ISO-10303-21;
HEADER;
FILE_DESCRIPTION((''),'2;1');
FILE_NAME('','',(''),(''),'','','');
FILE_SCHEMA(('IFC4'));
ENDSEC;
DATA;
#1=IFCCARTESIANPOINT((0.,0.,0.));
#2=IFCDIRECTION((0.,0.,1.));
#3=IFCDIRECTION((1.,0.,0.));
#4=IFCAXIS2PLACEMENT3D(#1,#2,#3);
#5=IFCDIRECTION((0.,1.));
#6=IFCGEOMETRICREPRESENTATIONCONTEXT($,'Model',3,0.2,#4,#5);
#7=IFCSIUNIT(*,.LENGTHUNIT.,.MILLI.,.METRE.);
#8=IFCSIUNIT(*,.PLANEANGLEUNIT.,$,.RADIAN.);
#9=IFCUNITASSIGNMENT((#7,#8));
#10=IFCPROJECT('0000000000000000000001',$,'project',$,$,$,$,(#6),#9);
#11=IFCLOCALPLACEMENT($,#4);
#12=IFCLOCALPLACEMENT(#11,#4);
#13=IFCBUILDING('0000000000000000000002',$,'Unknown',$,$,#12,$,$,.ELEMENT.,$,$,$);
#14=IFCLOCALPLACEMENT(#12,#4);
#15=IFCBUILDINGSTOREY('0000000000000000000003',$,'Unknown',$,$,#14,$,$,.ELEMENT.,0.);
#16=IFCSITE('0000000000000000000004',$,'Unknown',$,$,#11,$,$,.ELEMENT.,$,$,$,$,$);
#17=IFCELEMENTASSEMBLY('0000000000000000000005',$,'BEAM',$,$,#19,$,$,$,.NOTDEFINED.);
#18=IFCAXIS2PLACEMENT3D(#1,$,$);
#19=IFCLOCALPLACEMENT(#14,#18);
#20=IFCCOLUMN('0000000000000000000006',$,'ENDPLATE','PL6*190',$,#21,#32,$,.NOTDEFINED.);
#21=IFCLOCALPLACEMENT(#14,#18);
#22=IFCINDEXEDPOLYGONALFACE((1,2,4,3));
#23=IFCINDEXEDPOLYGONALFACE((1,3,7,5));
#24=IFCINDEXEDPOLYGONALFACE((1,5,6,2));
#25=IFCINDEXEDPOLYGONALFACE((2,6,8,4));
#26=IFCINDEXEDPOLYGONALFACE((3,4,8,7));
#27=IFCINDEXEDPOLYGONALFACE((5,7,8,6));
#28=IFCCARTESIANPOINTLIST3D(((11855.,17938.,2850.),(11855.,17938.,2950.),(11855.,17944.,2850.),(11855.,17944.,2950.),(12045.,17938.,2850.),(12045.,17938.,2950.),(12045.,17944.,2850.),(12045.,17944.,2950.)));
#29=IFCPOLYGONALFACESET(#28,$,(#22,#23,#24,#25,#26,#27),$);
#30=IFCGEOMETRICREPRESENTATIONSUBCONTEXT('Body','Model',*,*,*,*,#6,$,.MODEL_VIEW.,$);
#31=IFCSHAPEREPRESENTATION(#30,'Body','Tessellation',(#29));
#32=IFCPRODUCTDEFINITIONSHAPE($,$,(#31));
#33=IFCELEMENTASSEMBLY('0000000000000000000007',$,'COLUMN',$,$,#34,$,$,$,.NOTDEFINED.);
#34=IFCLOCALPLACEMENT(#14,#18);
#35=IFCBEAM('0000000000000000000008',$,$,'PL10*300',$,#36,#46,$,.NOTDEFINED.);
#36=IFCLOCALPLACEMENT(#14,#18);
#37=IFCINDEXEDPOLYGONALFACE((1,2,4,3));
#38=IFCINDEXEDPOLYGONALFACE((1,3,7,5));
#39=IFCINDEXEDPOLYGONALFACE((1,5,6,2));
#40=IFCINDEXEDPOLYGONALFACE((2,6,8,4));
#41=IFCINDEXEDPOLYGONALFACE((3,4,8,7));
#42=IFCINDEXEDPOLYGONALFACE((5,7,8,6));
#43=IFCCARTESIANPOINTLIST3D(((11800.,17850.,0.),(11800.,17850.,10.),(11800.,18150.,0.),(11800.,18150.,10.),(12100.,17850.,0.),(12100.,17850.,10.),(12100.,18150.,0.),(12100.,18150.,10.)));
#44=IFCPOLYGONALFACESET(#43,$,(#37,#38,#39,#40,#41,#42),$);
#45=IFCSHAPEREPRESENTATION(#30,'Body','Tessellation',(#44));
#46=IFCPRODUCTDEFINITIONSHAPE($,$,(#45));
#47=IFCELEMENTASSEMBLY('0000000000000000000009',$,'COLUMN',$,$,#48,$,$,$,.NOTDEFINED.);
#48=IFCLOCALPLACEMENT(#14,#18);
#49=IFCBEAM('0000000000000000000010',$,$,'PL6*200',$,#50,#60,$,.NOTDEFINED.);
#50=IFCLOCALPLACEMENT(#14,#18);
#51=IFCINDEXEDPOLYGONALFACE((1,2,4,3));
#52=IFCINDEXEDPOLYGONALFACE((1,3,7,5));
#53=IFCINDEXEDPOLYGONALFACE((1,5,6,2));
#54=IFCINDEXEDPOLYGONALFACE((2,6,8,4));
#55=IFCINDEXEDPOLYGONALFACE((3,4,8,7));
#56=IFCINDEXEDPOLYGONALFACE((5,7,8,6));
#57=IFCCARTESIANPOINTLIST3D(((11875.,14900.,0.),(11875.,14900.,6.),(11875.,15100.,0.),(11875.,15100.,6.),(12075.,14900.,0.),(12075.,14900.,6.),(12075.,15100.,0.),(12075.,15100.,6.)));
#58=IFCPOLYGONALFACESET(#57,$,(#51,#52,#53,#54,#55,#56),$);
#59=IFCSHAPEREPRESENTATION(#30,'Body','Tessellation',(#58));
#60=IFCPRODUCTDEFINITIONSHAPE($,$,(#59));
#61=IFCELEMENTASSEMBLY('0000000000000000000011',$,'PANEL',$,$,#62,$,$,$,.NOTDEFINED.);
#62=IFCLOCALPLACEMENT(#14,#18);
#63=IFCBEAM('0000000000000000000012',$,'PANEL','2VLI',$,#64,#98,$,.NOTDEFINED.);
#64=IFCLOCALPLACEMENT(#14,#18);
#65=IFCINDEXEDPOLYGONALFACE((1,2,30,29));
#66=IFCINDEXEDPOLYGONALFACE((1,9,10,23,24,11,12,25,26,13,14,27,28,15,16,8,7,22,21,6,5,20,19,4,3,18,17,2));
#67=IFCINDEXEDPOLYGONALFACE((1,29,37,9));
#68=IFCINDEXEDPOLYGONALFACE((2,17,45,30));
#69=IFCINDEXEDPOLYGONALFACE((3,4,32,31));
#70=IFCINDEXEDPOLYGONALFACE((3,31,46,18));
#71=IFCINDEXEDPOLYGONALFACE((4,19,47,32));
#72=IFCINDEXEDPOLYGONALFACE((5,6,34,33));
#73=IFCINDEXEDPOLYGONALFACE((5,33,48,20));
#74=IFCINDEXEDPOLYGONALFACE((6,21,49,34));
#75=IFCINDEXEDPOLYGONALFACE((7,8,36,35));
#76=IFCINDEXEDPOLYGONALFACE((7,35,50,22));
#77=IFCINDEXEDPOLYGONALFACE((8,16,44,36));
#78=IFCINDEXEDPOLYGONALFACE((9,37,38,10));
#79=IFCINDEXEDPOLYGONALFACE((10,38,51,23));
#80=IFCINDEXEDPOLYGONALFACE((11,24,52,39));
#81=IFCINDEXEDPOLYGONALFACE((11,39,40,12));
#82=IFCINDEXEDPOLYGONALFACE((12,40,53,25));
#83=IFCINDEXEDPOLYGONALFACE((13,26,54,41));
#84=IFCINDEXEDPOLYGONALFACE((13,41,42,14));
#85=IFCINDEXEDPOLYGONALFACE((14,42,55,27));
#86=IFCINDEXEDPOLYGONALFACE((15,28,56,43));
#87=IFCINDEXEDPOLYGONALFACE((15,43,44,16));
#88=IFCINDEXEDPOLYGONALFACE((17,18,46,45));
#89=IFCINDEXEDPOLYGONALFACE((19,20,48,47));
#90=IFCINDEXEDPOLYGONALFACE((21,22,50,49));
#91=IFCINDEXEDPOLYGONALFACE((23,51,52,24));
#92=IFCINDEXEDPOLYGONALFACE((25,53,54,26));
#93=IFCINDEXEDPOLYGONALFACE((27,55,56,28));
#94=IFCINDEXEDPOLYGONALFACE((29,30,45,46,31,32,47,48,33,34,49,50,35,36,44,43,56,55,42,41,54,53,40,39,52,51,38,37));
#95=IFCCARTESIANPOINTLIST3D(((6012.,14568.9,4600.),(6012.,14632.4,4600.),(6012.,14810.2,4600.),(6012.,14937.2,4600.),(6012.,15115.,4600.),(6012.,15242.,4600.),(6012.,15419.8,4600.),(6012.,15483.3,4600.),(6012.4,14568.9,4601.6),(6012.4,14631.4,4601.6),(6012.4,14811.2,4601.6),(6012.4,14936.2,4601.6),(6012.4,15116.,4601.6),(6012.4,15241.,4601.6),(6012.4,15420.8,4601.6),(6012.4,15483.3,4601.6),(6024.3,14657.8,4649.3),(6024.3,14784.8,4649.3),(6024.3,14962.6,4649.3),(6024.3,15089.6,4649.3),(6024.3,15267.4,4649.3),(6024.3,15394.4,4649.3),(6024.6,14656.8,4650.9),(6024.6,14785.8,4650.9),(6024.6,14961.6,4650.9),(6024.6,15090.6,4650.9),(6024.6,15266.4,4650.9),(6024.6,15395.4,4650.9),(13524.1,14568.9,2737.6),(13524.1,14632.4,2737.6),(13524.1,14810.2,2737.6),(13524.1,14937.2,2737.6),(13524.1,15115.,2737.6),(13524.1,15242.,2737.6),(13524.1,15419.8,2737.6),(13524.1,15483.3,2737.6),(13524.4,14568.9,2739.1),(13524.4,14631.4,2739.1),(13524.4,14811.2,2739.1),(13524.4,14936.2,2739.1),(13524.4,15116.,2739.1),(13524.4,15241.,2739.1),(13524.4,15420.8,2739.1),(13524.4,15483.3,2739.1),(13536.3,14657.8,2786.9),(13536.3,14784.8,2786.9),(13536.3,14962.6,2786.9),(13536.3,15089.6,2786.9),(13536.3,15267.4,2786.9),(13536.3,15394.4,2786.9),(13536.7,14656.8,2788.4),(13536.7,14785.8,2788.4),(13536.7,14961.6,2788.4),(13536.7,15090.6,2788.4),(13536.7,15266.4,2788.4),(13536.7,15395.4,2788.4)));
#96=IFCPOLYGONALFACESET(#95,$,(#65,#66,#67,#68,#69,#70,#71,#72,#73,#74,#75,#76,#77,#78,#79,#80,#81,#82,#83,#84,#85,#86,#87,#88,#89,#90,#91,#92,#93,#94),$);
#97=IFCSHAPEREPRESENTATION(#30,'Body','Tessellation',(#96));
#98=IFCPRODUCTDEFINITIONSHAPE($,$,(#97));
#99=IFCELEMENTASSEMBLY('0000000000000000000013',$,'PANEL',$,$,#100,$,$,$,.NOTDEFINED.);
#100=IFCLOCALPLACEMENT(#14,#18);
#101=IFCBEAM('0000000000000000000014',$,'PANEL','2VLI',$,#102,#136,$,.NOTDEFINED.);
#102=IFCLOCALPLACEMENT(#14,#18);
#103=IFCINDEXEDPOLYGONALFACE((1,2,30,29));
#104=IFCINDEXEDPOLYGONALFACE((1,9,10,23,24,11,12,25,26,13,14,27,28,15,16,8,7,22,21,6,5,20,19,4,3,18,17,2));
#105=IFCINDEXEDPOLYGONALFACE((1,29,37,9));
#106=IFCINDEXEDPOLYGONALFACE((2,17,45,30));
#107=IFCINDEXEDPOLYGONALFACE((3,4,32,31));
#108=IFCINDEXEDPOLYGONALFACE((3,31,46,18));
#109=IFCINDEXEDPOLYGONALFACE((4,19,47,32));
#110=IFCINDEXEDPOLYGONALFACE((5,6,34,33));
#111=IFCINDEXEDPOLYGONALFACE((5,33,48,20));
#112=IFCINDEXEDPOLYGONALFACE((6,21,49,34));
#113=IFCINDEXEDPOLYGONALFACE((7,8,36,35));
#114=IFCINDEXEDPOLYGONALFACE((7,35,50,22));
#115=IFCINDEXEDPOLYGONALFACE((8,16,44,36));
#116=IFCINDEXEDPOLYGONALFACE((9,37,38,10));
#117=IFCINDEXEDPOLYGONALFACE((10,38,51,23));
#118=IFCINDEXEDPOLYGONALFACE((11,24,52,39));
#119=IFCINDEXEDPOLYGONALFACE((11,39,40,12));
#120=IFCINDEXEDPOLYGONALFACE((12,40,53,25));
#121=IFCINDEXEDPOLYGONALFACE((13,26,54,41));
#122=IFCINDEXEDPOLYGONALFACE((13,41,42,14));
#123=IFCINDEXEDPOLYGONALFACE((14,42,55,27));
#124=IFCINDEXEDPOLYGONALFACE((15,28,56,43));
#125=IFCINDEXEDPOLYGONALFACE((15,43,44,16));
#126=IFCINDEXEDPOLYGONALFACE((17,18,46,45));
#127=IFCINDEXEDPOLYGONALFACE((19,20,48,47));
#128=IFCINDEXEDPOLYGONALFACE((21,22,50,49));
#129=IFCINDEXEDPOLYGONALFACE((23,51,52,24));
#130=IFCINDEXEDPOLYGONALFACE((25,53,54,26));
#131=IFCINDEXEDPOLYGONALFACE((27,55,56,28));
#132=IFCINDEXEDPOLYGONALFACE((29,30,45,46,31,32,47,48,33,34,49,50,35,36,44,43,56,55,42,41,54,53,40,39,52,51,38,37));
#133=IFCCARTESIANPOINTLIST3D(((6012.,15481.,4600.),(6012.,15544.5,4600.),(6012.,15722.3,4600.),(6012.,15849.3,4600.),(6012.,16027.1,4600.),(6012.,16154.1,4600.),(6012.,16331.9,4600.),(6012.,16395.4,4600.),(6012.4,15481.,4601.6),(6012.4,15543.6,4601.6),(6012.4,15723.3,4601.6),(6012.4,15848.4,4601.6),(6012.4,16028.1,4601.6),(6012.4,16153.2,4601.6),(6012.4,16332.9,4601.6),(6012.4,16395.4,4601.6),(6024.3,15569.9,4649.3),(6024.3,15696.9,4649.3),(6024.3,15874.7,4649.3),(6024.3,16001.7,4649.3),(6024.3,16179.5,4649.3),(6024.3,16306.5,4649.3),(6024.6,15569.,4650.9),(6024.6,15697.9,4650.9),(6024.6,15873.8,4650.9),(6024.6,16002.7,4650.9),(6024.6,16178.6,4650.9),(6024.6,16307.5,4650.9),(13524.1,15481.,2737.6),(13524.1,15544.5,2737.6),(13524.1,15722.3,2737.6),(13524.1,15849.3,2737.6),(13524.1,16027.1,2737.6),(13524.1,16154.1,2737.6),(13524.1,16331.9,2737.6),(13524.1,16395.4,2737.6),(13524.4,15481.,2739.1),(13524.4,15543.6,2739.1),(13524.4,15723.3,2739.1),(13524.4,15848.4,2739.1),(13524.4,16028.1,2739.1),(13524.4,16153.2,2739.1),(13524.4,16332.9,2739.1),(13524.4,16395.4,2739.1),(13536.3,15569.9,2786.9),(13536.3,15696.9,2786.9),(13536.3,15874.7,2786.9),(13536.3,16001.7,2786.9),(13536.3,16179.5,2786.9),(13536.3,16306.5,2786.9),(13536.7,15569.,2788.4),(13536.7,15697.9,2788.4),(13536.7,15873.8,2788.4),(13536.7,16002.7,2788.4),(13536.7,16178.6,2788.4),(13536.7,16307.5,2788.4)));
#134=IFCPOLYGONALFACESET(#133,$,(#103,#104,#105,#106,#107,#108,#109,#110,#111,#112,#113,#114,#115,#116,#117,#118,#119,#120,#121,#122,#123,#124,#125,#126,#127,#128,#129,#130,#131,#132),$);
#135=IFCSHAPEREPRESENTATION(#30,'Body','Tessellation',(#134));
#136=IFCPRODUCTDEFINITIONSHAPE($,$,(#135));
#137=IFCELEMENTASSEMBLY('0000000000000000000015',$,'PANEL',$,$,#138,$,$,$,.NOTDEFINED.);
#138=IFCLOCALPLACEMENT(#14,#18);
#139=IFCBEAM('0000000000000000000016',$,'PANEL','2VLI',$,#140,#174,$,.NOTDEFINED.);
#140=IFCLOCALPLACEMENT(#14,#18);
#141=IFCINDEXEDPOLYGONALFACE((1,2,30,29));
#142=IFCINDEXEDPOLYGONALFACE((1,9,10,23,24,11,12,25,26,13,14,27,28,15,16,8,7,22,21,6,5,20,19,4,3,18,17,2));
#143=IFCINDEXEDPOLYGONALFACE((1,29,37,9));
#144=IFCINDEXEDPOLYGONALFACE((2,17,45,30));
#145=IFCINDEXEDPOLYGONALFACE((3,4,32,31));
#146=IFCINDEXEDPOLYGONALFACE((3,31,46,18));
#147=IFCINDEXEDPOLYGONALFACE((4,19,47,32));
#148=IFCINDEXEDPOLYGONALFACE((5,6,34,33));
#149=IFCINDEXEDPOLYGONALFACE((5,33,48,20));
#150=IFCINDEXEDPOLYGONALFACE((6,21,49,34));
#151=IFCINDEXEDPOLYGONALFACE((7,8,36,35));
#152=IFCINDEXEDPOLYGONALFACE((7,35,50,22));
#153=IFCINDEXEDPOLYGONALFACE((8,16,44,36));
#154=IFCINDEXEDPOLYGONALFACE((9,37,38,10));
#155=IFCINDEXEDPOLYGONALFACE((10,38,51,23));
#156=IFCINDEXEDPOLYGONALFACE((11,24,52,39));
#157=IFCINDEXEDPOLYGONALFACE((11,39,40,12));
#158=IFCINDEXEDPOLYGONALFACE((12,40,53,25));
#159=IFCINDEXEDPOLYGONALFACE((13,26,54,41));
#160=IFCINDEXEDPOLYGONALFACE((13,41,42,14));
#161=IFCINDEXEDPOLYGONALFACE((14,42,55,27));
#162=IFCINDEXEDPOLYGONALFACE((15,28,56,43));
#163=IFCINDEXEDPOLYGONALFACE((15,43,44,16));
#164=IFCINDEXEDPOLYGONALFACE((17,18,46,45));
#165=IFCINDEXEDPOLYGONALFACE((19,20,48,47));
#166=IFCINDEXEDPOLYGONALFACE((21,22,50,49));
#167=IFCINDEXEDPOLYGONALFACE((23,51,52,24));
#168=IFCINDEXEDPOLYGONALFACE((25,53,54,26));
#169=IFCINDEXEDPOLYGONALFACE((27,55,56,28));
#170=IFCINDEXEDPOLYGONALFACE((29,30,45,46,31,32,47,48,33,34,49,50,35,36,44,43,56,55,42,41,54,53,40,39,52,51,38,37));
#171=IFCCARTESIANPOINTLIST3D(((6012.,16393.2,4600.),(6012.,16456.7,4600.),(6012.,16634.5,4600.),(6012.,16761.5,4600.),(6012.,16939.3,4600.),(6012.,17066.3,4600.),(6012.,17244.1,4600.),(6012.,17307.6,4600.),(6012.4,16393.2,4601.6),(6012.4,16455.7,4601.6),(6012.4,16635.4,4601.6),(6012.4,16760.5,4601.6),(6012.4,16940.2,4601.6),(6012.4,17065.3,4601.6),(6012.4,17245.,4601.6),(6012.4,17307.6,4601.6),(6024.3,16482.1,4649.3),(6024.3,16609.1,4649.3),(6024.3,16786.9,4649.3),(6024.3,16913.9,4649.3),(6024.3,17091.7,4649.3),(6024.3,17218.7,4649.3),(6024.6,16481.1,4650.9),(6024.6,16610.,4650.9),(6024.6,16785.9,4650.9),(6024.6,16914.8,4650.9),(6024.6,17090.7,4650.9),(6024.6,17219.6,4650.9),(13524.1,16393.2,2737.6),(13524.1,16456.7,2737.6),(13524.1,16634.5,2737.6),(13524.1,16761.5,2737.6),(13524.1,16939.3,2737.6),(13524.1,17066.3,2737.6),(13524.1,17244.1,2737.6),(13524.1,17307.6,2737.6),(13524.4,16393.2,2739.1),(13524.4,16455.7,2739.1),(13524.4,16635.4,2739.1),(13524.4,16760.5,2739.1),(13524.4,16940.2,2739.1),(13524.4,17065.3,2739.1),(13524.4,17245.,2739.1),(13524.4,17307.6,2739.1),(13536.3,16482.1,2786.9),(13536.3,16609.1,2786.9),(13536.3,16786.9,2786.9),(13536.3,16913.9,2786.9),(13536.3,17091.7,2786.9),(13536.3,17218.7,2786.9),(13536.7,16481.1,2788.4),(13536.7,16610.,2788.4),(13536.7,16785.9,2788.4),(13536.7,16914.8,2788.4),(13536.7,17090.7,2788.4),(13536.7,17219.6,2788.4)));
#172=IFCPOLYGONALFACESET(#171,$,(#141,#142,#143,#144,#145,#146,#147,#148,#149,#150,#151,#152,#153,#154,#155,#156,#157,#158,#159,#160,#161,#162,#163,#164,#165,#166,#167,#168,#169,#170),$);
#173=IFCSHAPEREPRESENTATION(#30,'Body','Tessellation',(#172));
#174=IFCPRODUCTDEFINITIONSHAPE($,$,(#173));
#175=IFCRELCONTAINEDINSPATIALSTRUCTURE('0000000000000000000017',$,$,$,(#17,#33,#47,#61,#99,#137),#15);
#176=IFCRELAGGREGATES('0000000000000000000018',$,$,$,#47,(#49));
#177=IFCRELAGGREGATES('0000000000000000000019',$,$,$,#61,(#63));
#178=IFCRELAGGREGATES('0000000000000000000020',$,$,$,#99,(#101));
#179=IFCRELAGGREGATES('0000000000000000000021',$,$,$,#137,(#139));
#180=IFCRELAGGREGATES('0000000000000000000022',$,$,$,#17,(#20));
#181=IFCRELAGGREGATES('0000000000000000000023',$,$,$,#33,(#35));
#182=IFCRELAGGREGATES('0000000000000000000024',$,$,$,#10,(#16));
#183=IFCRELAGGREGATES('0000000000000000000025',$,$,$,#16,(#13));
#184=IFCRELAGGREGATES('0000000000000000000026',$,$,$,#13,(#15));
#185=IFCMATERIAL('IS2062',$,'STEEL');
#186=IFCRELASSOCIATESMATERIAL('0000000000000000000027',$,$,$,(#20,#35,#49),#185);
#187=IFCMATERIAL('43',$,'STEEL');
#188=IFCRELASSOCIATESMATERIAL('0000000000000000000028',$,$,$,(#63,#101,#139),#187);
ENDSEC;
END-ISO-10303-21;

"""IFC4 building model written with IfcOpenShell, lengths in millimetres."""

from ifc_helpers import new_model, si_unit, direction, frame, origin_with_axes, place, context, subcontext, project, spatial, line, indexed_curve, outline, extrude, material, element, aggregate, save


model = new_model("IFC4")

# Units and contexts
model_context = context("Model", 3, precision=0.2, world=origin_with_axes(), true_north=direction((0.0, 1.0)))
body_context = subcontext(model_context, "Body", "Model", "MODEL_VIEW")
ifc_project = project(units=[si_unit("LENGTHUNIT", "METRE", prefix="MILLI"), si_unit("PLANEANGLEUNIT", "RADIAN")], contexts=[model_context])

# Site, building, storey
site_placement = place(None, origin_with_axes())
site = spatial("IfcSite", under=ifc_project, at=site_placement, Name="Unknown", CompositionType="ELEMENT")
building_placement = place(site_placement, origin_with_axes())
building = spatial("IfcBuilding", under=site, at=building_placement, Name="Unknown", CompositionType="ELEMENT")
storey_placement = place(building_placement, origin_with_axes())
storey = spatial("IfcBuildingStorey", under=building, at=storey_placement, Name="Unknown", CompositionType="ELEMENT", Elevation=0.0)

# Element assembly, column
assembly_1_placement = place(storey_placement, frame((11950.0, 18000.0, 2900.0), z_axis=(-1.0, 0.0, 0.0), x_axis=(0.0, -1.0, 0.0)))
assembly_1 = element("IfcElementAssembly", 1, at=assembly_1_placement, inside=storey, Name="BEAM", PredefinedType="NOTDEFINED")
ifc_material_1 = material(Name="IS2062", Category="STEEL")
column_placement = place(assembly_1_placement, frame((59.0, -50.0, 0.0), z_axis=(1.0, 0.0, 0.0), x_axis=(0.0, 1.0, 0.0)))
column = element("IfcColumn", 2, at=column_placement, material=ifc_material_1, Name="ENDPLATE", Description="PL6*190", PredefinedType="NOTDEFINED", context=body_context, shape_type="SolidModel", body=[
    extrude(outline(indexed_curve([(-3.0, -95.0), (3.0, -95.0), (3.0, 95.0), (-3.0, 95.0)], segments=[line(1, 2, 3, 4, 1)])), frame((0.0, 0.0, 0.0), z_axis=(-1.0, 0.0, 0.0), x_axis=(0.0, 0.0, 1.0)), (0.0, 0.0, -1.0), 100.0),
])

# Element assemblies, beams
assembly_2_placement = place(storey_placement, frame((11950.0, 18000.0, 0.0), z_axis=(0.0, 1.0, 0.0), x_axis=(0.0, 0.0, 1.0)))
assembly_2 = element("IfcElementAssembly", 3, at=assembly_2_placement, inside=storey, Name="COLUMN", PredefinedType="NOTDEFINED")
beam_1_placement = place(assembly_2_placement, frame((5.0, -150.0, 0.0), z_axis=(1.0, 0.0, 0.0), x_axis=(0.0, 1.0, 0.0)))
beam_1 = element("IfcBeam", 4, at=beam_1_placement, material=ifc_material_1, Description="PL10*300", PredefinedType="NOTDEFINED", context=body_context, shape_type="SolidModel", body=[
    extrude(outline(indexed_curve([(-5.0, -150.0), (5.0, -150.0), (5.0, 150.0), (-5.0, 150.0)], segments=[line(1, 2, 3, 4, 1)])), frame((0.0, 0.0, 0.0), z_axis=(-1.0, 0.0, 0.0), x_axis=(0.0, 0.0, 1.0)), (0.0, 0.0, -1.0), 300.0),
])
assembly_3_placement = place(storey_placement, frame((11975.0, 15000.0, 0.0), z_axis=(0.0, 1.0, 0.0), x_axis=(0.0, 0.0, 1.0)))
assembly_3 = element("IfcElementAssembly", 5, at=assembly_3_placement, inside=storey, Name="COLUMN", PredefinedType="NOTDEFINED")
beam_2_placement = place(assembly_3_placement, frame((3.0, -100.0, 0.0), z_axis=(1.0, 0.0, 0.0), x_axis=(0.0, 1.0, 0.0)))
beam_2 = element("IfcBeam", 6, at=beam_2_placement, material=ifc_material_1, Description="PL6*200", PredefinedType="NOTDEFINED", context=body_context, shape_type="SolidModel", body=[
    extrude(outline(indexed_curve([(-3.0, -100.0), (3.0, -100.0), (3.0, 100.0), (-3.0, 100.0)], segments=[line(1, 2, 3, 4, 1)])), frame((0.0, 0.0, 0.0), z_axis=(-1.0, 0.0, 0.0), x_axis=(0.0, 0.0, 1.0)), (0.0, 0.0, -1.0), 200.0),
])
aggregate(assembly_3, [beam_2])
assembly_4_placement = place(storey_placement, frame((6018.3, 15026.1, 4625.5), z_axis=(0.0, -1.0, 0.0), x_axis=(0.970613, 0.0, -0.240648)))
assembly_4 = element("IfcElementAssembly", 7, at=assembly_4_placement, inside=storey, Name="PANEL", PredefinedType="NOTDEFINED")
ifc_material_2 = material(Name="43", Category="STEEL")
beam_3_placement = place(assembly_4_placement, origin_with_axes())
beam_3 = element("IfcBeam", 8, at=beam_3_placement, material=ifc_material_2, Name="PANEL", Description="2VLI", PredefinedType="NOTDEFINED", context=body_context, shape_type="SolidModel", body=[
    extrude(outline(indexed_curve([(457.2, -26.2), (457.2, -24.6), (394.7, -24.6), (369.3, 26.2), (240.3, 26.2), (214.9, -24.6), (89.9, -24.6), (64.5, 26.2), (-64.5, 26.2), (-89.9, -24.6), (-214.9, -24.6), (-240.3, 26.2), (-369.3, 26.2), (-394.7, -24.6), (-457.2, -24.6), (-457.2, -26.2), (-393.7, -26.2), (-368.3, 24.6), (-241.3, 24.6), (-215.9, -26.2), (-88.9, -26.2), (-63.5, 24.6), (63.5, 24.6), (88.9, -26.2), (215.9, -26.2), (241.3, 24.6), (368.3, 24.6), (393.7, -26.2)], segments=[line(1, 2, 3, 4, 5, 6, 7, 8, 9, 10, 11, 12, 13, 14, 15, 16, 17, 18, 19, 20, 21, 22, 23, 24, 25, 26, 27, 28, 1)])), frame((0.0, 0.0, 0.0), z_axis=(-1.0, 0.0, 0.0), x_axis=(0.0, 0.0, 1.0)), (0.0, 0.0, -1.0), 7739.5),
])
aggregate(assembly_4, [beam_3])
assembly_5_placement = place(storey_placement, frame((6018.3, 15938.2, 4625.5), z_axis=(0.0, -1.0, 0.0), x_axis=(0.970613, 0.0, -0.240648)))
assembly_5 = element("IfcElementAssembly", 9, at=assembly_5_placement, inside=storey, Name="PANEL", PredefinedType="NOTDEFINED")
beam_4_placement = place(assembly_5_placement, origin_with_axes())
beam_4 = element("IfcBeam", 10, at=beam_4_placement, material=ifc_material_2, Name="PANEL", Description="2VLI", PredefinedType="NOTDEFINED", context=body_context, shape_type="SolidModel", body=[
    extrude(outline(indexed_curve([(457.2, -26.2), (457.2, -24.6), (394.7, -24.6), (369.3, 26.2), (240.3, 26.2), (214.9, -24.6), (89.9, -24.6), (64.5, 26.2), (-64.5, 26.2), (-89.9, -24.6), (-214.9, -24.6), (-240.3, 26.2), (-369.3, 26.2), (-394.7, -24.6), (-457.2, -24.6), (-457.2, -26.2), (-393.7, -26.2), (-368.3, 24.6), (-241.3, 24.6), (-215.9, -26.2), (-88.9, -26.2), (-63.5, 24.6), (63.5, 24.6), (88.9, -26.2), (215.9, -26.2), (241.3, 24.6), (368.3, 24.6), (393.7, -26.2)], segments=[line(1, 2, 3, 4, 5, 6, 7, 8, 9, 10, 11, 12, 13, 14, 15, 16, 17, 18, 19, 20, 21, 22, 23, 24, 25, 26, 27, 28, 1)])), frame((0.0, 0.0, 0.0), z_axis=(-1.0, 0.0, 0.0), x_axis=(0.0, 0.0, 1.0)), (0.0, 0.0, -1.0), 7739.5),
])
aggregate(assembly_5, [beam_4])
assembly_6_placement = place(storey_placement, frame((6018.3, 16850.4, 4625.5), z_axis=(0.0, -1.0, 0.0), x_axis=(0.970613, 0.0, -0.240648)))
assembly_6 = element("IfcElementAssembly", 11, at=assembly_6_placement, inside=storey, Name="PANEL", PredefinedType="NOTDEFINED")
beam_5_placement = place(assembly_6_placement, origin_with_axes())
beam_5 = element("IfcBeam", 12, at=beam_5_placement, material=ifc_material_2, Name="PANEL", Description="2VLI", PredefinedType="NOTDEFINED", context=body_context, shape_type="SolidModel", body=[
    extrude(outline(indexed_curve([(457.2, -26.2), (457.2, -24.6), (394.7, -24.6), (369.3, 26.2), (240.3, 26.2), (214.9, -24.6), (89.9, -24.6), (64.5, 26.2), (-64.5, 26.2), (-89.9, -24.6), (-214.9, -24.6), (-240.3, 26.2), (-369.3, 26.2), (-394.7, -24.6), (-457.2, -24.6), (-457.2, -26.2), (-393.7, -26.2), (-368.3, 24.6), (-241.3, 24.6), (-215.9, -26.2), (-88.9, -26.2), (-63.5, 24.6), (63.5, 24.6), (88.9, -26.2), (215.9, -26.2), (241.3, 24.6), (368.3, 24.6), (393.7, -26.2)], segments=[line(1, 2, 3, 4, 5, 6, 7, 8, 9, 10, 11, 12, 13, 14, 15, 16, 17, 18, 19, 20, 21, 22, 23, 24, 25, 26, 27, 28, 1)])), frame((0.0, 0.0, 0.0), z_axis=(-1.0, 0.0, 0.0), x_axis=(0.0, 0.0, 1.0)), (0.0, 0.0, -1.0), 7739.5),
])
aggregate(assembly_6, [beam_5])

aggregate(assembly_1, [column])
aggregate(assembly_2, [beam_1])

save(model, "model.ifc")
